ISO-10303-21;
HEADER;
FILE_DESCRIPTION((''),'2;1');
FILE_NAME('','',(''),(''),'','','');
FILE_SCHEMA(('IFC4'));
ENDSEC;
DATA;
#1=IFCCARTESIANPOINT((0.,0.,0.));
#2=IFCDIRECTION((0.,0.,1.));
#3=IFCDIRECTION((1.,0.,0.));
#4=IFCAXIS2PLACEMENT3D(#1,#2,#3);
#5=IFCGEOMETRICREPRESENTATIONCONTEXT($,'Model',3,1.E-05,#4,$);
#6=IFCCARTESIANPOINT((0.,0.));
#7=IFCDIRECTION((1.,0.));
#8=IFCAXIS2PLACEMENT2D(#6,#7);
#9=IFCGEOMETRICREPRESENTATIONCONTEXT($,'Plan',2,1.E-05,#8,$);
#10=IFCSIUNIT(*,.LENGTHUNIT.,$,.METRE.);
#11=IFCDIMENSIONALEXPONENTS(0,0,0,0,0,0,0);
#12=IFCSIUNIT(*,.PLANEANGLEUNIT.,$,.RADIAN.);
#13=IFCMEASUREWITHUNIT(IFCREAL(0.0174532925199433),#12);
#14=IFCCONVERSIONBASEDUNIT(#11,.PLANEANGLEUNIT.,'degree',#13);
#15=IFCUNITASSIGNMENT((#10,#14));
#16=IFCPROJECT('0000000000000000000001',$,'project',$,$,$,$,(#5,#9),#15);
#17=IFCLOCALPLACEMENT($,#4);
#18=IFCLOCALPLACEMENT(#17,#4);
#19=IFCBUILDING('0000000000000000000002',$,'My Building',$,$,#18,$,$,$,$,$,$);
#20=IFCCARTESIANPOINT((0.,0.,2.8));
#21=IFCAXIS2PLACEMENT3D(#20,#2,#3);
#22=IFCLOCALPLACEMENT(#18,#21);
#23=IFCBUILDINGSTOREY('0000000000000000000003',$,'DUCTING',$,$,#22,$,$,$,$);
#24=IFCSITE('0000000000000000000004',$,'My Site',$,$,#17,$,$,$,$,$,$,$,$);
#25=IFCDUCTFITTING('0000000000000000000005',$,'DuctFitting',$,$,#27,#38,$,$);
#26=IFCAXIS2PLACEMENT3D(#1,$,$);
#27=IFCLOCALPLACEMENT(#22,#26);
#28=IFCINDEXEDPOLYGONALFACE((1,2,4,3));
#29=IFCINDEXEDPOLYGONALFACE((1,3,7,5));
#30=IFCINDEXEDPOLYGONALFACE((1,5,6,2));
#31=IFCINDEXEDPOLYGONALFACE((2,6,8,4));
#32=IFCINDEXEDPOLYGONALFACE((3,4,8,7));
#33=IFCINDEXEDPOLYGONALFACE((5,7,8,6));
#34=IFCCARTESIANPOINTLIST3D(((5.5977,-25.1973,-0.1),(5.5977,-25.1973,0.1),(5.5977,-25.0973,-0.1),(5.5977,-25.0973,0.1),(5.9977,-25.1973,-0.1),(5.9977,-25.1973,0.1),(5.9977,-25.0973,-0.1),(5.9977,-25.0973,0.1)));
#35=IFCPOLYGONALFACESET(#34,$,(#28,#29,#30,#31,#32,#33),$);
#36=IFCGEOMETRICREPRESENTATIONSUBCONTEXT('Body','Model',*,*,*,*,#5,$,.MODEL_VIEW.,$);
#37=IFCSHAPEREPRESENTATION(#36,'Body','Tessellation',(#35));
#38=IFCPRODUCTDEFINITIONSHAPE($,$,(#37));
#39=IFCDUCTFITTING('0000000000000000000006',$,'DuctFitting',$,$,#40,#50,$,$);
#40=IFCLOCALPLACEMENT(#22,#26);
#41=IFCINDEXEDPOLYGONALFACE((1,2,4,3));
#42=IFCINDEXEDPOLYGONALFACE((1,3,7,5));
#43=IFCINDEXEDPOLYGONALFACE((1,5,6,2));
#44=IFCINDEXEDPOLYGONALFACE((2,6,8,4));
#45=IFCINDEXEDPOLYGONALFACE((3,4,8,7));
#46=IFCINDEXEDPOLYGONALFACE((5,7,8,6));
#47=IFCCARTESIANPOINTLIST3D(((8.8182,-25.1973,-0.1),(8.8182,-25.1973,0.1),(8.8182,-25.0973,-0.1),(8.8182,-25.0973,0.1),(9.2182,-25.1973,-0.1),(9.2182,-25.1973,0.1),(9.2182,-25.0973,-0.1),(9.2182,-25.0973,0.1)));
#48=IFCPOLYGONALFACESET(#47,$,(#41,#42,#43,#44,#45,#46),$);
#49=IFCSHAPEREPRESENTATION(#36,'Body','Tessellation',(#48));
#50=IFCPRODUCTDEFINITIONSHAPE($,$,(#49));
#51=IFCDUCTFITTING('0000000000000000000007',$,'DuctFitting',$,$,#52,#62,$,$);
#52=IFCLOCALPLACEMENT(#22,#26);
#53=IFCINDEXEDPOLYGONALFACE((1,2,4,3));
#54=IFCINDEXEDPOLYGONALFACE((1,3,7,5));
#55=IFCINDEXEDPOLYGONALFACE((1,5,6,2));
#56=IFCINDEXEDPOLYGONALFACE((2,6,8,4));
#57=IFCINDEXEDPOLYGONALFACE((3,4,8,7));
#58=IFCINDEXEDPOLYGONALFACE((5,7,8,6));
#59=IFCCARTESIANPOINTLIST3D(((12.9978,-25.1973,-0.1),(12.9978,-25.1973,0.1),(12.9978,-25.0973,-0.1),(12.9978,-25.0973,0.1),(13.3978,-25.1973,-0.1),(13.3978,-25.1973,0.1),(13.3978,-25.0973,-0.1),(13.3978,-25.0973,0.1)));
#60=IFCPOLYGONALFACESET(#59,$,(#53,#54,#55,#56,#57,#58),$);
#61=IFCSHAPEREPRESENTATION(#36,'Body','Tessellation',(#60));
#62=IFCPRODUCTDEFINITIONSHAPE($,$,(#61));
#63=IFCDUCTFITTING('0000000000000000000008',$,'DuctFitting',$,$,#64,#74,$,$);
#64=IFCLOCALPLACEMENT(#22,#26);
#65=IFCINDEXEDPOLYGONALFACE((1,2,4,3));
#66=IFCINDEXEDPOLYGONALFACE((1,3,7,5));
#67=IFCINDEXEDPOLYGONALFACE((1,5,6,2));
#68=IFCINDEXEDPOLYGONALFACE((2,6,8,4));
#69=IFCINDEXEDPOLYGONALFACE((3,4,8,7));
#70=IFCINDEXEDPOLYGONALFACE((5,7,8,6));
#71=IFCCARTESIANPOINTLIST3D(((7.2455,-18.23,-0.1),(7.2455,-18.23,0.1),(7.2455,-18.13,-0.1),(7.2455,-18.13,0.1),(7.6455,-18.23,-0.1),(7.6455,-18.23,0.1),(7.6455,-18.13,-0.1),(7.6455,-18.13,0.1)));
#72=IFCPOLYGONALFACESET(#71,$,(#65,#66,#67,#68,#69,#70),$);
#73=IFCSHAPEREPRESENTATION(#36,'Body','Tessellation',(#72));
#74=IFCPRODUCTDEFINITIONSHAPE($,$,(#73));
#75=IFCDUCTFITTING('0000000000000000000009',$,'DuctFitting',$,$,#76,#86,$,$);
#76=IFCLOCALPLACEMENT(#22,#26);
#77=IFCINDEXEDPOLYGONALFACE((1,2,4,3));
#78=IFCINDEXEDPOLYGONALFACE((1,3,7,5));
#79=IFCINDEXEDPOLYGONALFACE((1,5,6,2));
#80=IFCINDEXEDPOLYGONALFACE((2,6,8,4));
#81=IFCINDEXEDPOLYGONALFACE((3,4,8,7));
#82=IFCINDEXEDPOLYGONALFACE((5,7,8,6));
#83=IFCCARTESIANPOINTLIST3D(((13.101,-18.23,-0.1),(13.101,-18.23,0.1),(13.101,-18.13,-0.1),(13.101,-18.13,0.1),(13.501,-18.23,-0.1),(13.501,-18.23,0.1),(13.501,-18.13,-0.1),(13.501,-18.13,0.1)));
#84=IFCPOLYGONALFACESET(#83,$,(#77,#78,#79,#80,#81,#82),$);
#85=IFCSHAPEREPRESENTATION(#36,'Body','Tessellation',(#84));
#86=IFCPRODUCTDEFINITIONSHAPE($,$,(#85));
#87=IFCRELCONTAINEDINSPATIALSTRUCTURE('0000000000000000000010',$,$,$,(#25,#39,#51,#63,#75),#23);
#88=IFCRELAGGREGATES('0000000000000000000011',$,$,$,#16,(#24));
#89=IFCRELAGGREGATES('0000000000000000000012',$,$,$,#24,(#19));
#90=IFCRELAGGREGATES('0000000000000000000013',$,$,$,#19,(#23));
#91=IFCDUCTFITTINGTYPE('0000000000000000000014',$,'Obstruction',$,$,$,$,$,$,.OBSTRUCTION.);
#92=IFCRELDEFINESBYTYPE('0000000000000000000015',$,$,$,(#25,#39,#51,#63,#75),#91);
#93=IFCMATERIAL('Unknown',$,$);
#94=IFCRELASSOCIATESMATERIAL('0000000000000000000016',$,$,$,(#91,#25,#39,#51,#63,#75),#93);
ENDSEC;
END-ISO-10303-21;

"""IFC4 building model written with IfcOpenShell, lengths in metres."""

from ifc_helpers import new_model, entity, si_unit, converted_unit, frame, origin_with_axes, origin_2d_with_axis, place, context, subcontext, project, spatial, rectangle, extrude, material, material_profile, profile_set, profile_usage, type_object, element, save


model = new_model("IFC4")

# Units and contexts
model_context = context("Model", 3, precision=1e-05, world=origin_with_axes())
plan_context = context("Plan", 2, precision=1e-05, world=origin_2d_with_axis())
body_context = subcontext(model_context, "Body", "Model", "MODEL_VIEW")
ifc_project = project(units=[si_unit("LENGTHUNIT", "METRE"), converted_unit("PLANEANGLEUNIT", "degree", entity("IfcReal", 0.0174532925199433), si_unit("PLANEANGLEUNIT", "RADIAN"), dimensions=[0, 0, 0, 0, 0, 0, 0])], contexts=[model_context, plan_context])

# Site, building, storey
site_placement = place(None, origin_with_axes())
site = spatial("IfcSite", under=ifc_project, at=site_placement, Name="My Site")
building_placement = place(site_placement, origin_with_axes())
building = spatial("IfcBuilding", under=site, at=building_placement, Name="My Building")
storey_placement = place(building_placement, frame((0.0, 0.0, 2.8), z_axis=(0.0, 0.0, 1.0), x_axis=(1.0, 0.0, 0.0)))
storey = spatial("IfcBuildingStorey", under=building, at=storey_placement, Name="DUCTING")

# Shared definitions
ifc_material = material(Name="Unknown")

# Duct fittings
ifc_material_profile_1 = material_profile(ifc_material, rectangle(XDim=0.4, YDim=0.2))
ifc_profile_set_1 = profile_set([ifc_material_profile_1])
duct_fitting_type_1 = type_object("IfcDuctFittingType", Name="Obstruction", PredefinedType="OBSTRUCTION", material=ifc_profile_set_1)
ifc_profile_usage_1 = profile_usage(ifc_profile_set_1, cardinal=5)
duct_fitting_1_placement = place(storey_placement, frame((5.7977, -25.0973, 0.0), z_axis=(0.0, -1.0, 0.0), x_axis=(1.0, 0.0, 0.0)))
element("IfcDuctFitting", 1, at=duct_fitting_1_placement, inside=storey, type_object=duct_fitting_type_1, material=ifc_profile_usage_1, Name="DuctFitting", context=body_context, shape_type="SweptSolid", body=[
    extrude(rectangle(XDim=0.4, YDim=0.2), origin_with_axes(), (0.0, 0.0, 1.0), 0.1),
])
ifc_profile_usage_2 = profile_usage(ifc_profile_set_1, cardinal=5)
duct_fitting_2_placement = place(storey_placement, frame((9.0182, -25.0973, 0.0), z_axis=(0.0, -1.0, 0.0), x_axis=(1.0, 0.0, 0.0)))
element("IfcDuctFitting", 2, at=duct_fitting_2_placement, inside=storey, type_object=duct_fitting_type_1, material=ifc_profile_usage_2, Name="DuctFitting", context=body_context, shape_type="SweptSolid", body=[
    extrude(rectangle(XDim=0.4, YDim=0.2), origin_with_axes(), (0.0, 0.0, 1.0), 0.1),
])
ifc_profile_usage_3 = profile_usage(ifc_profile_set_1, cardinal=5)
duct_fitting_3_placement = place(storey_placement, frame((13.1978, -25.0973, 0.0), z_axis=(0.0, -1.0, 0.0), x_axis=(1.0, 0.0, 0.0)))
element("IfcDuctFitting", 3, at=duct_fitting_3_placement, inside=storey, type_object=duct_fitting_type_1, material=ifc_profile_usage_3, Name="DuctFitting", context=body_context, shape_type="SweptSolid", body=[
    extrude(rectangle(XDim=0.4, YDim=0.2), origin_with_axes(), (0.0, 0.0, 1.0), 0.1),
])
ifc_profile_usage_4 = profile_usage(ifc_profile_set_1, cardinal=5)
duct_fitting_4_placement = place(storey_placement, frame((7.4455, -18.13, 0.0), z_axis=(0.0, -1.0, 0.0), x_axis=(1.0, 0.0, 0.0)))
element("IfcDuctFitting", 4, at=duct_fitting_4_placement, inside=storey, type_object=duct_fitting_type_1, material=ifc_profile_usage_4, Name="DuctFitting", context=body_context, shape_type="SweptSolid", body=[
    extrude(rectangle(XDim=0.4, YDim=0.2), origin_with_axes(), (0.0, 0.0, 1.0), 0.1),
])
ifc_profile_usage_5 = profile_usage(ifc_profile_set_1, cardinal=5)
duct_fitting_5_placement = place(storey_placement, frame((13.301, -18.13, 0.0), z_axis=(0.0, -1.0, 0.0), x_axis=(1.0, 0.0, 0.0)))
element("IfcDuctFitting", 5, at=duct_fitting_5_placement, inside=storey, type_object=duct_fitting_type_1, material=ifc_profile_usage_5, Name="DuctFitting", context=body_context, shape_type="SweptSolid", body=[
    extrude(rectangle(XDim=0.4, YDim=0.2), origin_with_axes(), (0.0, 0.0, 1.0), 0.1),
])

save(model, "model.ifc")
